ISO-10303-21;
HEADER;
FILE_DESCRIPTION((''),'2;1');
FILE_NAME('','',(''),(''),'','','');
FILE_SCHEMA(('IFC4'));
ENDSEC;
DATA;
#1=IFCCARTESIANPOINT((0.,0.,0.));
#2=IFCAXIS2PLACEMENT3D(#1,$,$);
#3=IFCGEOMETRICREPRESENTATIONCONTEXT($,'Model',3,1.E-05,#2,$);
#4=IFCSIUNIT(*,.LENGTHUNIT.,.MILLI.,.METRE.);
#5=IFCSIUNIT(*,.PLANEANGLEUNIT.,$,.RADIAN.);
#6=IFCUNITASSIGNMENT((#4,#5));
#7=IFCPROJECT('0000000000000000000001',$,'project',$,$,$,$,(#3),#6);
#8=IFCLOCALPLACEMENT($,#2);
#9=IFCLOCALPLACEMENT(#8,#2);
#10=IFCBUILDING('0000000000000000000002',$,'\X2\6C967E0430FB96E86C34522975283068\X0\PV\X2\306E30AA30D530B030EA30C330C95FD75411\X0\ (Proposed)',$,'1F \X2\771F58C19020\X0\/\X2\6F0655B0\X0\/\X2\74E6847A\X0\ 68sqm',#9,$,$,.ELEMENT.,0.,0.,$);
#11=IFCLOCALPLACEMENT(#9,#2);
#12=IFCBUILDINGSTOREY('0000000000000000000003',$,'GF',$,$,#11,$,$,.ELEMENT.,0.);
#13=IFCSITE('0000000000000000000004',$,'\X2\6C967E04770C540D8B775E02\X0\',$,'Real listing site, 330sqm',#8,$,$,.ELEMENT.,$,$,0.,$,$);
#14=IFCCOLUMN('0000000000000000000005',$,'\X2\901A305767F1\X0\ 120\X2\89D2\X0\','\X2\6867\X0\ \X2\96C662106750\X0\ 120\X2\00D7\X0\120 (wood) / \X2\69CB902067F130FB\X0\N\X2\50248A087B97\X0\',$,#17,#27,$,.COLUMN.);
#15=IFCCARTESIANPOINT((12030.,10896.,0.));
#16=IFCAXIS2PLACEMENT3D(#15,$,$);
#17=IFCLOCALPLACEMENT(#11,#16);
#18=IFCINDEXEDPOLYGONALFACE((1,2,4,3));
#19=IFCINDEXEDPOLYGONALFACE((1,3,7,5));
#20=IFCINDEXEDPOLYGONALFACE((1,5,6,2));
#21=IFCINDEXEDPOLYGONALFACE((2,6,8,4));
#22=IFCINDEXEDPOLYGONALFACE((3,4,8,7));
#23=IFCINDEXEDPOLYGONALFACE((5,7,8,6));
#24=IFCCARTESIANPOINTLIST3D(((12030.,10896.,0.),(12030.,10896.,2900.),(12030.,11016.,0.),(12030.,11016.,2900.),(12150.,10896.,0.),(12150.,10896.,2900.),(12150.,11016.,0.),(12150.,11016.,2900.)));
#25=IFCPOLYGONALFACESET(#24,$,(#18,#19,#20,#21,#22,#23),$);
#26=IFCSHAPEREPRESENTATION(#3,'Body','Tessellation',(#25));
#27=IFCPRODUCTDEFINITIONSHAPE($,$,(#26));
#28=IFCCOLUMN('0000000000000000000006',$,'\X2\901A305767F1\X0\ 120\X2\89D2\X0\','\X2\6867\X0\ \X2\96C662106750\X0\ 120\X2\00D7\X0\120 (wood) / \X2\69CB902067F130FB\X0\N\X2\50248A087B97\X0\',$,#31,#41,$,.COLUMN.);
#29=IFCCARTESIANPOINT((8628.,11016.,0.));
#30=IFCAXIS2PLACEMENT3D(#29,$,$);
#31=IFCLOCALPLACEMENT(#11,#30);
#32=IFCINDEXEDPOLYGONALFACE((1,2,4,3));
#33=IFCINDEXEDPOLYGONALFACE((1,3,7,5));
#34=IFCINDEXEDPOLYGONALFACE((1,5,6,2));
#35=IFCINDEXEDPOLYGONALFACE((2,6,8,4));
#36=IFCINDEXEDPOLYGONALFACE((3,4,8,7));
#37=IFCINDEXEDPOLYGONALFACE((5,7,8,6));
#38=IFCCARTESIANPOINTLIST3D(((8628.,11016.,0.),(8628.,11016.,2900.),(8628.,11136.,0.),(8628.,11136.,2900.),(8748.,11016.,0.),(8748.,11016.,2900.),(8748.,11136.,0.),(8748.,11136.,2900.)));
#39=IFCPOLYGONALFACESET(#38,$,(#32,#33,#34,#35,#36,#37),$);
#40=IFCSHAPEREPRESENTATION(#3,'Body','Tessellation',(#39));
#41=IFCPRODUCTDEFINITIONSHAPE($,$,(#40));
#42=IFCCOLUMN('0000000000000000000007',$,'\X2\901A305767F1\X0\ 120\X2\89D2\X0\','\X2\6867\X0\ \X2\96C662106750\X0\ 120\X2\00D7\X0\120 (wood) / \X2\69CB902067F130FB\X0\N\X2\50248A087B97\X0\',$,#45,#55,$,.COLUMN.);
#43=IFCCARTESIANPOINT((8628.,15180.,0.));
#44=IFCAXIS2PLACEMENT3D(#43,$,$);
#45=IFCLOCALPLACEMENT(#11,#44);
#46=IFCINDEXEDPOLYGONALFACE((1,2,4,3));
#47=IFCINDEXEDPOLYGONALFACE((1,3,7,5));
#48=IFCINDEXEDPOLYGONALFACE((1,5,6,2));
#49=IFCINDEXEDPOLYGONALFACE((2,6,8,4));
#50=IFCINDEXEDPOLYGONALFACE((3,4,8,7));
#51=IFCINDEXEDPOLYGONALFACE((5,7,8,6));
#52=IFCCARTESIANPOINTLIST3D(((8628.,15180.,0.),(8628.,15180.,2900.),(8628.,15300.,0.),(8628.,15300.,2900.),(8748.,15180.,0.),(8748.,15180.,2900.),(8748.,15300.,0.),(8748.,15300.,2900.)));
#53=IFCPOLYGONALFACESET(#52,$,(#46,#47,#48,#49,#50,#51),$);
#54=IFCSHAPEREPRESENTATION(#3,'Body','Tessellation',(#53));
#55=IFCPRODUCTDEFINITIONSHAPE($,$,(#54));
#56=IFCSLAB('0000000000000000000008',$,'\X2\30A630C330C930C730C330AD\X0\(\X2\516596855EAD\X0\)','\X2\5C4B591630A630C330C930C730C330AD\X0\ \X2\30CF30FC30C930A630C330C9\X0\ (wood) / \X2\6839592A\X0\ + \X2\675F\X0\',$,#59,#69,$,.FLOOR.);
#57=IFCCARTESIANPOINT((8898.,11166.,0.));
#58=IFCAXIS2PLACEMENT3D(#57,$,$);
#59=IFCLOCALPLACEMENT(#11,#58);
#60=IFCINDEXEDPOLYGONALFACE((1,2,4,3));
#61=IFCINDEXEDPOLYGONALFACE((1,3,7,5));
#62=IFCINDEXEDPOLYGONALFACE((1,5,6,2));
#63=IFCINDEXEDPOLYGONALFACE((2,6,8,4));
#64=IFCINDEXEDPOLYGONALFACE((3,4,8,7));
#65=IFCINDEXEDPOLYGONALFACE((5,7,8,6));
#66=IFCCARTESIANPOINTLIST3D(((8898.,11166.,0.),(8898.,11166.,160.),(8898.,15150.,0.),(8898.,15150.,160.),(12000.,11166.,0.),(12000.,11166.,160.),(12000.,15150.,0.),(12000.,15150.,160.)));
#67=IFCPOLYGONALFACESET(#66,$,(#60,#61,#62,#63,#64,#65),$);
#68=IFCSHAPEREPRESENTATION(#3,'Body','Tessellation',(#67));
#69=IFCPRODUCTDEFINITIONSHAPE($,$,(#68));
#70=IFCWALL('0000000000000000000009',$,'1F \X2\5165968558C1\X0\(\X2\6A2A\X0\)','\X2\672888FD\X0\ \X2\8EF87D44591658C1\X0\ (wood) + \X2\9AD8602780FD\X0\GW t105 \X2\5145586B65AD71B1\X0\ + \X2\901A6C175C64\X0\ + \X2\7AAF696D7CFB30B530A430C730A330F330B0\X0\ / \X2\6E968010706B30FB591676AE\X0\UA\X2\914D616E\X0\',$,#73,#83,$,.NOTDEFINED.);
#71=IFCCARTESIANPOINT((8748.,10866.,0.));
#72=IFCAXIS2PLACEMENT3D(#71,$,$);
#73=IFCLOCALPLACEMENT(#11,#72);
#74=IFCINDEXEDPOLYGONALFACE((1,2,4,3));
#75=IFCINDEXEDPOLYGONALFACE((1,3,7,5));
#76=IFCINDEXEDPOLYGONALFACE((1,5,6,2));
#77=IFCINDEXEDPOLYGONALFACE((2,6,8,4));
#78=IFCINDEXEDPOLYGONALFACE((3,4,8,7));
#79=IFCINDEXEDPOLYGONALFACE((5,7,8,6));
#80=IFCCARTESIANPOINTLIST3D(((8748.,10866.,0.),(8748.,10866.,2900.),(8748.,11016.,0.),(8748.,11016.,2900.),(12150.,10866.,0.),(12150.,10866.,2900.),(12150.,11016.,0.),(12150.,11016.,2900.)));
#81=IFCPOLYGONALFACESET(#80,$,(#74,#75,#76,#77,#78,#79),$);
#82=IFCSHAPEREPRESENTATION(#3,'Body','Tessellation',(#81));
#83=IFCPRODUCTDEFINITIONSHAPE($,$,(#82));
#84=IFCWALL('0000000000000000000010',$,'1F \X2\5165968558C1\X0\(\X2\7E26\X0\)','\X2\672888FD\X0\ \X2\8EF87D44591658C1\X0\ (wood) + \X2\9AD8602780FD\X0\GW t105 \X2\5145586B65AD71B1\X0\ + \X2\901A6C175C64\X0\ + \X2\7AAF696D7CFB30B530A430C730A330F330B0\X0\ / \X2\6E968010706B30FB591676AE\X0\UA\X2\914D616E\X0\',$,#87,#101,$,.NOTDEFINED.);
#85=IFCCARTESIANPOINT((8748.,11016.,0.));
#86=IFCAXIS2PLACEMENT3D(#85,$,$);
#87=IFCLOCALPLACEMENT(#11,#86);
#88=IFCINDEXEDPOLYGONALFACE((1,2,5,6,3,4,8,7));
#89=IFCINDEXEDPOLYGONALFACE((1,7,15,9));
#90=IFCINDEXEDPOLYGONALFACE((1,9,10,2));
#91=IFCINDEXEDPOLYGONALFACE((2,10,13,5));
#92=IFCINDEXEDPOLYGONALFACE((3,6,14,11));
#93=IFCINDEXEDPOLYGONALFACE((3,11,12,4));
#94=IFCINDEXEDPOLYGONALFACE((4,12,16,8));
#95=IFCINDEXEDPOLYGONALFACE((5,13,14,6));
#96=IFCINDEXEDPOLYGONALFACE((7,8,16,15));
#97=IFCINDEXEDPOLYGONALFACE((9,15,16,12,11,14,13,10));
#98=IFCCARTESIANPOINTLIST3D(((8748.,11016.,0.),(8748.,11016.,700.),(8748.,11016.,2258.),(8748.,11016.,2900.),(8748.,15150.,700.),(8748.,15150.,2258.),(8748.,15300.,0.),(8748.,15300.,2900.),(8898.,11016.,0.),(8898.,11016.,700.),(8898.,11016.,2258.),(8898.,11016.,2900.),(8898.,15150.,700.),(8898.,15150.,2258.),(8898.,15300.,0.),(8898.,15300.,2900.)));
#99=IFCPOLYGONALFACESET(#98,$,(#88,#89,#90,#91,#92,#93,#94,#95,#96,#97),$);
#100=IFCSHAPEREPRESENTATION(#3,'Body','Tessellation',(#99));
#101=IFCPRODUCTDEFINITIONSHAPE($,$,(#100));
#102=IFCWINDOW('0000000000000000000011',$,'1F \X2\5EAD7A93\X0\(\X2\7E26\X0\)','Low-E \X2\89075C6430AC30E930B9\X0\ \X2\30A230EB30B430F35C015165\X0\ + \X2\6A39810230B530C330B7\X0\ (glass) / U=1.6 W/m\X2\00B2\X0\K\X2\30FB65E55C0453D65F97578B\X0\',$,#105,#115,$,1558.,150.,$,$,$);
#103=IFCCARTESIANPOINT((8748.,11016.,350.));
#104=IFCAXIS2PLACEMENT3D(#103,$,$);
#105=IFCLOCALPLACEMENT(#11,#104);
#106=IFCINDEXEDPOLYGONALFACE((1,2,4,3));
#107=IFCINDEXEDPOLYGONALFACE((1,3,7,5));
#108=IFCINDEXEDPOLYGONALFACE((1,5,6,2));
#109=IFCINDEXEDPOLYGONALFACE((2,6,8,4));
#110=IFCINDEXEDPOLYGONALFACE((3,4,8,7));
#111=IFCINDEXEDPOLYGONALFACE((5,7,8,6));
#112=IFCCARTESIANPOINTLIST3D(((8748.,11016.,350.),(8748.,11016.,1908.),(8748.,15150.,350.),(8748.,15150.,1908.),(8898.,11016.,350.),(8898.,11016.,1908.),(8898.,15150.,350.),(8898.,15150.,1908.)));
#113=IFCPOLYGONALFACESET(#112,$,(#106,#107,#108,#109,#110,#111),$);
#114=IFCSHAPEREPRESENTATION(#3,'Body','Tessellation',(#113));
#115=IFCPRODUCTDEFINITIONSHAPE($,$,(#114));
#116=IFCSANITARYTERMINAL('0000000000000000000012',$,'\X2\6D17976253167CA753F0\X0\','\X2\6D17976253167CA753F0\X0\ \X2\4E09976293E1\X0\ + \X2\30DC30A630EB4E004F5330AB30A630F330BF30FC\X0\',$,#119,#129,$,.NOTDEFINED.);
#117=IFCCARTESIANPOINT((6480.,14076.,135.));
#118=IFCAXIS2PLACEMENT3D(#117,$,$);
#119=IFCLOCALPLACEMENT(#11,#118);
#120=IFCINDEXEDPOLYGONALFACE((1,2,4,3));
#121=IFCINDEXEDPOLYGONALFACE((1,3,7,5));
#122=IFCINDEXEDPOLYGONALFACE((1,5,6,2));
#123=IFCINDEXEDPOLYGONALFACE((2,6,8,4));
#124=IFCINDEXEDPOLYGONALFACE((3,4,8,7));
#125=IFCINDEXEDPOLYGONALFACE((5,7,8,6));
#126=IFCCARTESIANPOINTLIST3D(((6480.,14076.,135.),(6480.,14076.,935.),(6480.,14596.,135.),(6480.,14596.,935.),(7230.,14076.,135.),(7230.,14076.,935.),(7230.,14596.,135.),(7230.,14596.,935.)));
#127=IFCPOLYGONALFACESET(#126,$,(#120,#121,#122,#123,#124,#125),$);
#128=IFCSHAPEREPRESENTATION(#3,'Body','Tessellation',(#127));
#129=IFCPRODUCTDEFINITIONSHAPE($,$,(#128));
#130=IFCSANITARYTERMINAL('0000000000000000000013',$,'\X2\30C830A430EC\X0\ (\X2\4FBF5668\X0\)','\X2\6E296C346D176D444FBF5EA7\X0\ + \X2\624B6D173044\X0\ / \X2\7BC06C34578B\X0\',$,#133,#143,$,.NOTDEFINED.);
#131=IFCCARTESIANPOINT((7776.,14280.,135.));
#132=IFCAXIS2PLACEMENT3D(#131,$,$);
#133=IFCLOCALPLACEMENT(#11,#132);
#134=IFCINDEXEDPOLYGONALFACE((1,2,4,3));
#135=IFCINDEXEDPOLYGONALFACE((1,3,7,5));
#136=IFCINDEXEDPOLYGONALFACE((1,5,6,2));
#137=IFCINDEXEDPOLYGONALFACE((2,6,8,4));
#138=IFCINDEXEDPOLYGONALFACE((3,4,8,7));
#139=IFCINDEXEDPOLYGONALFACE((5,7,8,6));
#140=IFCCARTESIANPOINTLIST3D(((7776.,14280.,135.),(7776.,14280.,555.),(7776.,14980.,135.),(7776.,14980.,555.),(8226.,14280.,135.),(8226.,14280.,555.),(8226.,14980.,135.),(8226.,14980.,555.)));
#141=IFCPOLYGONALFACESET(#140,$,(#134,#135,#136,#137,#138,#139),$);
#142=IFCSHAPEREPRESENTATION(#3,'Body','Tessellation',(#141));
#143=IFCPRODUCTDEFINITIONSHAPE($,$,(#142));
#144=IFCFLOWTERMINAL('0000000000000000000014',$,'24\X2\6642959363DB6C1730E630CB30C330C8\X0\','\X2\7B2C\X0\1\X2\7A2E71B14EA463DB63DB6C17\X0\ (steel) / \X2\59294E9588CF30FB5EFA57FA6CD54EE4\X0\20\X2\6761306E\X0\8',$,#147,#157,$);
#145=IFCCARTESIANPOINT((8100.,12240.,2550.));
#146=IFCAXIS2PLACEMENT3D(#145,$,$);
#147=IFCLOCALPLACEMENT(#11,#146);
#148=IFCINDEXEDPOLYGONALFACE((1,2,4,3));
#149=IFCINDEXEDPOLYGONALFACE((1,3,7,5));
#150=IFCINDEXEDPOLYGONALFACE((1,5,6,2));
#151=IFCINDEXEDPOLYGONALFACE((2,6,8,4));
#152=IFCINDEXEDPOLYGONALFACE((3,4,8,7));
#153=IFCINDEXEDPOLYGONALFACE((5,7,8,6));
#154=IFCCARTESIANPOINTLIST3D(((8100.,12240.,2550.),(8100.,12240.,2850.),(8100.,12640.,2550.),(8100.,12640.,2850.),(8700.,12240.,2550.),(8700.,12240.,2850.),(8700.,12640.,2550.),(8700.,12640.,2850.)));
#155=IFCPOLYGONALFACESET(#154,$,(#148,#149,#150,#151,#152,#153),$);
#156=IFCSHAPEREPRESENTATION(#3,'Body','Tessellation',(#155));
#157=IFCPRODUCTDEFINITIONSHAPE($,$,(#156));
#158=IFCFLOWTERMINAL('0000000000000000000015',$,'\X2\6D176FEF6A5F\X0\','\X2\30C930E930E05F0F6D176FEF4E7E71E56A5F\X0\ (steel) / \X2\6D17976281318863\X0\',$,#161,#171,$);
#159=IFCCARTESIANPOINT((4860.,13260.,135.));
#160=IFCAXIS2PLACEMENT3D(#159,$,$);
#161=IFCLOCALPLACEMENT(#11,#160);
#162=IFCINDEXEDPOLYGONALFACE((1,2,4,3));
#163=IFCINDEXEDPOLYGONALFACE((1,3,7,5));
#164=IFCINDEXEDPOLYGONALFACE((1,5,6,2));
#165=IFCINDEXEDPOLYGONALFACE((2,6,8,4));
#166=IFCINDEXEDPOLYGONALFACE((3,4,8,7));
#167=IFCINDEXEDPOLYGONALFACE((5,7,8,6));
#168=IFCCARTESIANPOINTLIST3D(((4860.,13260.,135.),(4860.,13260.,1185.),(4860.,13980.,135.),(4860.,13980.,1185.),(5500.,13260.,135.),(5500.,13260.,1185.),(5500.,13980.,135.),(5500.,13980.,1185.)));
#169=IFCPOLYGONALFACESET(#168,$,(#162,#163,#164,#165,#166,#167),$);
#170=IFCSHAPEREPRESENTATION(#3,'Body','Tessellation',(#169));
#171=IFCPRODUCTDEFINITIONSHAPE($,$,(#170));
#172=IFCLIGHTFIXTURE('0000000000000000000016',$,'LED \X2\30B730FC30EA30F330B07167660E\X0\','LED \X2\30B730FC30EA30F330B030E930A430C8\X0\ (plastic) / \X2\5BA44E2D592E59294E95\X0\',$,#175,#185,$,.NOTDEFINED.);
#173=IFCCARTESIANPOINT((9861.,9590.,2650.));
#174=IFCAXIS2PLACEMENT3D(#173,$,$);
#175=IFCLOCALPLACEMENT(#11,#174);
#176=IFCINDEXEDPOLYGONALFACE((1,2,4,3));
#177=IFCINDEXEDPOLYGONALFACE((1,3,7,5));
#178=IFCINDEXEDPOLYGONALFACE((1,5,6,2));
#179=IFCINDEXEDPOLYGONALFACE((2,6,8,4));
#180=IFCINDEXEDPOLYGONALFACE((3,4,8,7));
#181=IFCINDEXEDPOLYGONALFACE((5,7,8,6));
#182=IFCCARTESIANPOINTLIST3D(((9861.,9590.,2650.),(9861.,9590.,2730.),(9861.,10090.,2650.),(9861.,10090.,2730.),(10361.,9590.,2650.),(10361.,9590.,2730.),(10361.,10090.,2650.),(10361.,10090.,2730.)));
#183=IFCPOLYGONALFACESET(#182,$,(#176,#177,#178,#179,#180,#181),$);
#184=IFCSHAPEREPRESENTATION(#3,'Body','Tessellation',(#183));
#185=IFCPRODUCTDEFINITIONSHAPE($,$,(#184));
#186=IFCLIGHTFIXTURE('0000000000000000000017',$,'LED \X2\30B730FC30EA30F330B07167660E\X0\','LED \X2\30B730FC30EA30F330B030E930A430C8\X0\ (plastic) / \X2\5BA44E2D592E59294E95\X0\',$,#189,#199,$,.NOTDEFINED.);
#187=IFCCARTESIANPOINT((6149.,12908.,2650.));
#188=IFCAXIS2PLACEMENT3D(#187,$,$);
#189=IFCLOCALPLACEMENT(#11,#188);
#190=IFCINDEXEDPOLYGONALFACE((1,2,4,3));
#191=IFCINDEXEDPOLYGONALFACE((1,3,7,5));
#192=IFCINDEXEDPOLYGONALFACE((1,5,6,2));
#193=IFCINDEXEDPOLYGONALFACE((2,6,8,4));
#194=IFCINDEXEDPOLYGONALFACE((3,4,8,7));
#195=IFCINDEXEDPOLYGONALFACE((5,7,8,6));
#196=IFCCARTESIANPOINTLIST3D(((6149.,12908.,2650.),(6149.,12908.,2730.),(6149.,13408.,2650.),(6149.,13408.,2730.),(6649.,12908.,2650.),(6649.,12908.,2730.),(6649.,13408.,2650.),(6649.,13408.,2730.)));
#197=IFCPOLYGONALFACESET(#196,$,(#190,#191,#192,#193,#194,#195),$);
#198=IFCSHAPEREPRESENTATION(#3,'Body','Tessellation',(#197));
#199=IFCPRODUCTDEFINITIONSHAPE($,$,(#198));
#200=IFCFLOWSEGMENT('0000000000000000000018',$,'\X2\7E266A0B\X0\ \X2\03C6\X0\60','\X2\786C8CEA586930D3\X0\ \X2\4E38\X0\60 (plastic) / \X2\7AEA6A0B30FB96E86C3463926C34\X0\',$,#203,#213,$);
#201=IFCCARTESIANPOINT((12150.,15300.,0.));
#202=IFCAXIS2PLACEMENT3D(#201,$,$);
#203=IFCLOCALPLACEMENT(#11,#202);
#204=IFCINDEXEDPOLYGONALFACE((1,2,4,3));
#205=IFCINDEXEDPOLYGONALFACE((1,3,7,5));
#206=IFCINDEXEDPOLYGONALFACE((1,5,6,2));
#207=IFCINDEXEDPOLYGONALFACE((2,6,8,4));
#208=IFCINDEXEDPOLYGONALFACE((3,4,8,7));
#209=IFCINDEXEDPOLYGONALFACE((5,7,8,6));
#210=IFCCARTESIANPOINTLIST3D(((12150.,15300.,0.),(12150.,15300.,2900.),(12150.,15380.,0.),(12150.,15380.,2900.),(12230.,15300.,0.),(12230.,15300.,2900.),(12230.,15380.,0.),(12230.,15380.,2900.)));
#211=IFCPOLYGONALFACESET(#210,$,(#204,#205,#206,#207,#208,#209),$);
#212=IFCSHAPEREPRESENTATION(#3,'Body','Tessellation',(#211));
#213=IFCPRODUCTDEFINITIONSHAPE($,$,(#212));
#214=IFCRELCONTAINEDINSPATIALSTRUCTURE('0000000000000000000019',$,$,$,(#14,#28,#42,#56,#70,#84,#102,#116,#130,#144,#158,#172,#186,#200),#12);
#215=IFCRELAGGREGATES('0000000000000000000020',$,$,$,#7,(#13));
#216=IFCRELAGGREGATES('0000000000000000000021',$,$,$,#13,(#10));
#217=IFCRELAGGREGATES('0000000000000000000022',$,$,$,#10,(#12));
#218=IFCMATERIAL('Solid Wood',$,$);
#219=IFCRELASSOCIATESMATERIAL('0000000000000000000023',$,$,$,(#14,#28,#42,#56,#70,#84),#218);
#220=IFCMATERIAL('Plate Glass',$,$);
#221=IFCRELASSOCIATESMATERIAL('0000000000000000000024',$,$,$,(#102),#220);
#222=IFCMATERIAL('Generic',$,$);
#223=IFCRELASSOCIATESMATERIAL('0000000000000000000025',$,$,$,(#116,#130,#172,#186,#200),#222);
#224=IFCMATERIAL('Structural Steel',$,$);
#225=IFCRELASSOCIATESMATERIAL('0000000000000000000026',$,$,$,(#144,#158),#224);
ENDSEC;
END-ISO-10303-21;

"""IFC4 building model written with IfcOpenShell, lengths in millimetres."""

from ifc_helpers import new_model, si_unit, frame, frame_2d, origin, place, context, project, spatial, rectangle, extrude, material, element, fill, save


model = new_model("IFC4")

# Units and contexts
model_context = context("Model", 3, precision=1e-05, world=origin())
ifc_project = project(units=[si_unit("LENGTHUNIT", "METRE", prefix="MILLI"), si_unit("PLANEANGLEUNIT", "RADIAN")], contexts=[model_context])

# Site, building, storey
site_placement = place(None, origin())
site = spatial("IfcSite", under=ifc_project, at=site_placement, Name="沖縄県名護市", ObjectType="Real listing site, 330sqm", CompositionType="ELEMENT", RefElevation=0.0)
building_placement = place(site_placement, origin())
building = spatial("IfcBuilding", under=site, at=building_placement, Name="沖縄・雨水利用とPVのオフグリッド志向 (Proposed)", ObjectType="1F 真壁造/漆喰/瓦葺 68sqm", CompositionType="ELEMENT", ElevationOfRefHeight=0.0, ElevationOfTerrain=0.0)
storey_placement = place(building_placement, origin())
storey = spatial("IfcBuildingStorey", under=building, at=storey_placement, Name="GF", CompositionType="ELEMENT", Elevation=0.0)

# Columns
ifc_material_1 = material(Name="Solid Wood")
column_1_placement = place(storey_placement, frame((12030.0, 10896.0, 0.0)))
element("IfcColumn", 1, at=column_1_placement, inside=storey, material=ifc_material_1, Name="通し柱 120角", Description="桧 集成材 120×120 (wood) / 構造柱・N値計算", PredefinedType="COLUMN", context=model_context, shape_type="SweptSolid", body=[
    extrude(rectangle(XDim=120.0, YDim=120.0, at=frame_2d((60.0, 60.0))), frame((12030.0, 10896.0, 0.0)), (0.0, 0.0, 1.0), 2900.0),
])
column_2_placement = place(storey_placement, frame((8628.0, 11016.0, 0.0)))
element("IfcColumn", 2, at=column_2_placement, inside=storey, material=ifc_material_1, Name="通し柱 120角", Description="桧 集成材 120×120 (wood) / 構造柱・N値計算", PredefinedType="COLUMN", context=model_context, shape_type="SweptSolid", body=[
    extrude(rectangle(XDim=120.0, YDim=120.0, at=frame_2d((60.0, 60.0))), frame((8628.0, 11016.0, 0.0)), (0.0, 0.0, 1.0), 2900.0),
])
column_3_placement = place(storey_placement, frame((8628.0, 15180.0, 0.0)))
element("IfcColumn", 3, at=column_3_placement, inside=storey, material=ifc_material_1, Name="通し柱 120角", Description="桧 集成材 120×120 (wood) / 構造柱・N値計算", PredefinedType="COLUMN", context=model_context, shape_type="SweptSolid", body=[
    extrude(rectangle(XDim=120.0, YDim=120.0, at=frame_2d((60.0, 60.0))), frame((8628.0, 15180.0, 0.0)), (0.0, 0.0, 1.0), 2900.0),
])

# Slab
slab_placement = place(storey_placement, frame((8898.0, 11166.0, 0.0)))
element("IfcSlab", 4, at=slab_placement, inside=storey, material=ifc_material_1, Name="ウッドデッキ(入隅庭)", Description="屋外ウッドデッキ ハードウッド (wood) / 根太 + 束", PredefinedType="FLOOR", context=model_context, shape_type="SweptSolid", body=[
    extrude(rectangle(XDim=3102.0, YDim=3984.0, at=frame_2d((1551.0, 1992.0))), frame((8898.0, 11166.0, 0.0)), (0.0, 0.0, 1.0), 160.0),
])

# Wall
wall_1_placement = place(storey_placement, frame((8748.0, 10866.0, 0.0)))
element("IfcWall", 5, at=wall_1_placement, inside=storey, material=ifc_material_1, Name="1F 入隅壁(横)", Description="木製 軸組外壁 (wood) + 高性能GW t105 充填断熱 + 通気層 + 窯業系サイディング / 準耐火・外皮UA配慮", PredefinedType="NOTDEFINED", context=model_context, shape_type="SweptSolid", body=[
    extrude(rectangle(XDim=3402.0, YDim=150.0, at=frame_2d((1701.0, 75.0))), frame((8748.0, 10866.0, 0.0)), (0.0, 0.0, 1.0), 2900.0),
])

# Wall, opening, window
wall_2_placement = place(storey_placement, frame((8748.0, 11016.0, 0.0)))
wall_2 = element("IfcWall", 6, at=wall_2_placement, inside=storey, material=ifc_material_1, Name="1F 入隅壁(縦)", Description="木製 軸組外壁 (wood) + 高性能GW t105 充填断熱 + 通気層 + 窯業系サイディング / 準耐火・外皮UA配慮", PredefinedType="NOTDEFINED", context=model_context, shape_type="SweptSolid", body=[
    extrude(rectangle(XDim=150.0, YDim=4284.0, at=frame_2d((75.0, 2142.0))), frame((8748.0, 11016.0, 0.0)), (0.0, 0.0, 1.0), 2900.0),
])
opening_placement = place(storey_placement, frame((8748.0, 11016.0, 350.0)))
opening = element("IfcOpeningElement", 7, at=opening_placement, cuts=wall_2, PredefinedType="NOTDEFINED", context=model_context, shape_type="SweptSolid", body=[
    extrude(rectangle(XDim=150.0, YDim=4134.0, at=frame_2d((75.0, 2067.0))), frame((8748.0, 11016.0, 350.0)), (0.0, 0.0, 1.0), 1558.0),
])
ifc_material_2 = material(Name="Plate Glass")
window_placement = place(storey_placement, frame((8748.0, 11016.0, 350.0)))
window = element("IfcWindow", 8, at=window_placement, inside=storey, material=ifc_material_2, Name="1F 庭窓(縦)", Description="Low-E 複層ガラス アルゴン封入 + 樹脂サッシ (glass) / U=1.6 W/m²K・日射取得型", OverallHeight=1558.0, OverallWidth=150.0, context=model_context, shape_type="SweptSolid", body=[
    extrude(rectangle(XDim=150.0, YDim=4134.0, at=frame_2d((75.0, 2067.0))), frame((8748.0, 11016.0, 350.0)), (0.0, 0.0, 1.0), 1558.0),
])
fill(opening, window)

# Sanitary terminals
ifc_material_3 = material(Name="Generic")
sanitary_terminal_1_placement = place(storey_placement, frame((6480.0, 14076.0, 135.0)))
element("IfcSanitaryTerminal", 9, at=sanitary_terminal_1_placement, inside=storey, material=ifc_material_3, Name="洗面化粧台", Description="洗面化粧台 三面鏡 + ボウル一体カウンター", PredefinedType="NOTDEFINED", context=model_context, shape_type="SweptSolid", body=[
    extrude(rectangle(XDim=750.0, YDim=520.0, at=frame_2d((375.0, 260.0))), frame((6480.0, 14076.0, 135.0)), (0.0, 0.0, 1.0), 800.0),
])
sanitary_terminal_2_placement = place(storey_placement, frame((7776.0, 14280.0, 135.0)))
element("IfcSanitaryTerminal", 10, at=sanitary_terminal_2_placement, inside=storey, material=ifc_material_3, Name="トイレ (便器)", Description="温水洗浄便座 + 手洗い / 節水型", PredefinedType="NOTDEFINED", context=model_context, shape_type="SweptSolid", body=[
    extrude(rectangle(XDim=450.0, YDim=700.0, at=frame_2d((225.0, 350.0))), frame((7776.0, 14280.0, 135.0)), (0.0, 0.0, 1.0), 420.0),
])

# Flow terminals
ifc_material_4 = material(Name="Structural Steel")
flow_terminal_1_placement = place(storey_placement, frame((8100.0, 12240.0, 2550.0)))
element("IfcFlowTerminal", 11, at=flow_terminal_1_placement, inside=storey, material=ifc_material_4, Name="24時間換気ユニット", Description="第1種熱交換換気 (steel) / 天井裏・建基法令20条の8", context=model_context, shape_type="SweptSolid", body=[
    extrude(rectangle(XDim=600.0, YDim=400.0, at=frame_2d((300.0, 200.0))), frame((8100.0, 12240.0, 2550.0)), (0.0, 0.0, 1.0), 300.0),
])
flow_terminal_2_placement = place(storey_placement, frame((4860.0, 13260.0, 135.0)))
element("IfcFlowTerminal", 12, at=flow_terminal_2_placement, inside=storey, material=ifc_material_4, Name="洗濯機", Description="ドラム式洗濯乾燥機 (steel) / 洗面脱衣", context=model_context, shape_type="SweptSolid", body=[
    extrude(rectangle(XDim=640.0, YDim=720.0, at=frame_2d((320.0, 360.0))), frame((4860.0, 13260.0, 135.0)), (0.0, 0.0, 1.0), 1050.0),
])

# Light fixtures
light_fixture_1_placement = place(storey_placement, frame((9861.0, 9590.0, 2650.0)))
element("IfcLightFixture", 13, at=light_fixture_1_placement, inside=storey, material=ifc_material_3, Name="LED シーリング照明", Description="LED シーリングライト (plastic) / 室中央天井", PredefinedType="NOTDEFINED", context=model_context, shape_type="SweptSolid", body=[
    extrude(rectangle(XDim=500.0, YDim=500.0, at=frame_2d((250.0, 250.0))), frame((9861.0, 9590.0, 2650.0)), (0.0, 0.0, 1.0), 80.0),
])
light_fixture_2_placement = place(storey_placement, frame((6149.0, 12908.0, 2650.0)))
element("IfcLightFixture", 14, at=light_fixture_2_placement, inside=storey, material=ifc_material_3, Name="LED シーリング照明", Description="LED シーリングライト (plastic) / 室中央天井", PredefinedType="NOTDEFINED", context=model_context, shape_type="SweptSolid", body=[
    extrude(rectangle(XDim=500.0, YDim=500.0, at=frame_2d((250.0, 250.0))), frame((6149.0, 12908.0, 2650.0)), (0.0, 0.0, 1.0), 80.0),
])

# Flow segment
flow_segment_placement = place(storey_placement, frame((12150.0, 15300.0, 0.0)))
element("IfcFlowSegment", 15, at=flow_segment_placement, inside=storey, material=ifc_material_3, Name="縦樋 φ60", Description="硬質塩ビ 丸60 (plastic) / 竪樋・雨水排水", context=model_context, shape_type="SweptSolid", body=[
    extrude(rectangle(XDim=80.0, YDim=80.0, at=frame_2d((40.0, 40.0))), frame((12150.0, 15300.0, 0.0)), (0.0, 0.0, 1.0), 2900.0),
])

save(model, "model.ifc")
